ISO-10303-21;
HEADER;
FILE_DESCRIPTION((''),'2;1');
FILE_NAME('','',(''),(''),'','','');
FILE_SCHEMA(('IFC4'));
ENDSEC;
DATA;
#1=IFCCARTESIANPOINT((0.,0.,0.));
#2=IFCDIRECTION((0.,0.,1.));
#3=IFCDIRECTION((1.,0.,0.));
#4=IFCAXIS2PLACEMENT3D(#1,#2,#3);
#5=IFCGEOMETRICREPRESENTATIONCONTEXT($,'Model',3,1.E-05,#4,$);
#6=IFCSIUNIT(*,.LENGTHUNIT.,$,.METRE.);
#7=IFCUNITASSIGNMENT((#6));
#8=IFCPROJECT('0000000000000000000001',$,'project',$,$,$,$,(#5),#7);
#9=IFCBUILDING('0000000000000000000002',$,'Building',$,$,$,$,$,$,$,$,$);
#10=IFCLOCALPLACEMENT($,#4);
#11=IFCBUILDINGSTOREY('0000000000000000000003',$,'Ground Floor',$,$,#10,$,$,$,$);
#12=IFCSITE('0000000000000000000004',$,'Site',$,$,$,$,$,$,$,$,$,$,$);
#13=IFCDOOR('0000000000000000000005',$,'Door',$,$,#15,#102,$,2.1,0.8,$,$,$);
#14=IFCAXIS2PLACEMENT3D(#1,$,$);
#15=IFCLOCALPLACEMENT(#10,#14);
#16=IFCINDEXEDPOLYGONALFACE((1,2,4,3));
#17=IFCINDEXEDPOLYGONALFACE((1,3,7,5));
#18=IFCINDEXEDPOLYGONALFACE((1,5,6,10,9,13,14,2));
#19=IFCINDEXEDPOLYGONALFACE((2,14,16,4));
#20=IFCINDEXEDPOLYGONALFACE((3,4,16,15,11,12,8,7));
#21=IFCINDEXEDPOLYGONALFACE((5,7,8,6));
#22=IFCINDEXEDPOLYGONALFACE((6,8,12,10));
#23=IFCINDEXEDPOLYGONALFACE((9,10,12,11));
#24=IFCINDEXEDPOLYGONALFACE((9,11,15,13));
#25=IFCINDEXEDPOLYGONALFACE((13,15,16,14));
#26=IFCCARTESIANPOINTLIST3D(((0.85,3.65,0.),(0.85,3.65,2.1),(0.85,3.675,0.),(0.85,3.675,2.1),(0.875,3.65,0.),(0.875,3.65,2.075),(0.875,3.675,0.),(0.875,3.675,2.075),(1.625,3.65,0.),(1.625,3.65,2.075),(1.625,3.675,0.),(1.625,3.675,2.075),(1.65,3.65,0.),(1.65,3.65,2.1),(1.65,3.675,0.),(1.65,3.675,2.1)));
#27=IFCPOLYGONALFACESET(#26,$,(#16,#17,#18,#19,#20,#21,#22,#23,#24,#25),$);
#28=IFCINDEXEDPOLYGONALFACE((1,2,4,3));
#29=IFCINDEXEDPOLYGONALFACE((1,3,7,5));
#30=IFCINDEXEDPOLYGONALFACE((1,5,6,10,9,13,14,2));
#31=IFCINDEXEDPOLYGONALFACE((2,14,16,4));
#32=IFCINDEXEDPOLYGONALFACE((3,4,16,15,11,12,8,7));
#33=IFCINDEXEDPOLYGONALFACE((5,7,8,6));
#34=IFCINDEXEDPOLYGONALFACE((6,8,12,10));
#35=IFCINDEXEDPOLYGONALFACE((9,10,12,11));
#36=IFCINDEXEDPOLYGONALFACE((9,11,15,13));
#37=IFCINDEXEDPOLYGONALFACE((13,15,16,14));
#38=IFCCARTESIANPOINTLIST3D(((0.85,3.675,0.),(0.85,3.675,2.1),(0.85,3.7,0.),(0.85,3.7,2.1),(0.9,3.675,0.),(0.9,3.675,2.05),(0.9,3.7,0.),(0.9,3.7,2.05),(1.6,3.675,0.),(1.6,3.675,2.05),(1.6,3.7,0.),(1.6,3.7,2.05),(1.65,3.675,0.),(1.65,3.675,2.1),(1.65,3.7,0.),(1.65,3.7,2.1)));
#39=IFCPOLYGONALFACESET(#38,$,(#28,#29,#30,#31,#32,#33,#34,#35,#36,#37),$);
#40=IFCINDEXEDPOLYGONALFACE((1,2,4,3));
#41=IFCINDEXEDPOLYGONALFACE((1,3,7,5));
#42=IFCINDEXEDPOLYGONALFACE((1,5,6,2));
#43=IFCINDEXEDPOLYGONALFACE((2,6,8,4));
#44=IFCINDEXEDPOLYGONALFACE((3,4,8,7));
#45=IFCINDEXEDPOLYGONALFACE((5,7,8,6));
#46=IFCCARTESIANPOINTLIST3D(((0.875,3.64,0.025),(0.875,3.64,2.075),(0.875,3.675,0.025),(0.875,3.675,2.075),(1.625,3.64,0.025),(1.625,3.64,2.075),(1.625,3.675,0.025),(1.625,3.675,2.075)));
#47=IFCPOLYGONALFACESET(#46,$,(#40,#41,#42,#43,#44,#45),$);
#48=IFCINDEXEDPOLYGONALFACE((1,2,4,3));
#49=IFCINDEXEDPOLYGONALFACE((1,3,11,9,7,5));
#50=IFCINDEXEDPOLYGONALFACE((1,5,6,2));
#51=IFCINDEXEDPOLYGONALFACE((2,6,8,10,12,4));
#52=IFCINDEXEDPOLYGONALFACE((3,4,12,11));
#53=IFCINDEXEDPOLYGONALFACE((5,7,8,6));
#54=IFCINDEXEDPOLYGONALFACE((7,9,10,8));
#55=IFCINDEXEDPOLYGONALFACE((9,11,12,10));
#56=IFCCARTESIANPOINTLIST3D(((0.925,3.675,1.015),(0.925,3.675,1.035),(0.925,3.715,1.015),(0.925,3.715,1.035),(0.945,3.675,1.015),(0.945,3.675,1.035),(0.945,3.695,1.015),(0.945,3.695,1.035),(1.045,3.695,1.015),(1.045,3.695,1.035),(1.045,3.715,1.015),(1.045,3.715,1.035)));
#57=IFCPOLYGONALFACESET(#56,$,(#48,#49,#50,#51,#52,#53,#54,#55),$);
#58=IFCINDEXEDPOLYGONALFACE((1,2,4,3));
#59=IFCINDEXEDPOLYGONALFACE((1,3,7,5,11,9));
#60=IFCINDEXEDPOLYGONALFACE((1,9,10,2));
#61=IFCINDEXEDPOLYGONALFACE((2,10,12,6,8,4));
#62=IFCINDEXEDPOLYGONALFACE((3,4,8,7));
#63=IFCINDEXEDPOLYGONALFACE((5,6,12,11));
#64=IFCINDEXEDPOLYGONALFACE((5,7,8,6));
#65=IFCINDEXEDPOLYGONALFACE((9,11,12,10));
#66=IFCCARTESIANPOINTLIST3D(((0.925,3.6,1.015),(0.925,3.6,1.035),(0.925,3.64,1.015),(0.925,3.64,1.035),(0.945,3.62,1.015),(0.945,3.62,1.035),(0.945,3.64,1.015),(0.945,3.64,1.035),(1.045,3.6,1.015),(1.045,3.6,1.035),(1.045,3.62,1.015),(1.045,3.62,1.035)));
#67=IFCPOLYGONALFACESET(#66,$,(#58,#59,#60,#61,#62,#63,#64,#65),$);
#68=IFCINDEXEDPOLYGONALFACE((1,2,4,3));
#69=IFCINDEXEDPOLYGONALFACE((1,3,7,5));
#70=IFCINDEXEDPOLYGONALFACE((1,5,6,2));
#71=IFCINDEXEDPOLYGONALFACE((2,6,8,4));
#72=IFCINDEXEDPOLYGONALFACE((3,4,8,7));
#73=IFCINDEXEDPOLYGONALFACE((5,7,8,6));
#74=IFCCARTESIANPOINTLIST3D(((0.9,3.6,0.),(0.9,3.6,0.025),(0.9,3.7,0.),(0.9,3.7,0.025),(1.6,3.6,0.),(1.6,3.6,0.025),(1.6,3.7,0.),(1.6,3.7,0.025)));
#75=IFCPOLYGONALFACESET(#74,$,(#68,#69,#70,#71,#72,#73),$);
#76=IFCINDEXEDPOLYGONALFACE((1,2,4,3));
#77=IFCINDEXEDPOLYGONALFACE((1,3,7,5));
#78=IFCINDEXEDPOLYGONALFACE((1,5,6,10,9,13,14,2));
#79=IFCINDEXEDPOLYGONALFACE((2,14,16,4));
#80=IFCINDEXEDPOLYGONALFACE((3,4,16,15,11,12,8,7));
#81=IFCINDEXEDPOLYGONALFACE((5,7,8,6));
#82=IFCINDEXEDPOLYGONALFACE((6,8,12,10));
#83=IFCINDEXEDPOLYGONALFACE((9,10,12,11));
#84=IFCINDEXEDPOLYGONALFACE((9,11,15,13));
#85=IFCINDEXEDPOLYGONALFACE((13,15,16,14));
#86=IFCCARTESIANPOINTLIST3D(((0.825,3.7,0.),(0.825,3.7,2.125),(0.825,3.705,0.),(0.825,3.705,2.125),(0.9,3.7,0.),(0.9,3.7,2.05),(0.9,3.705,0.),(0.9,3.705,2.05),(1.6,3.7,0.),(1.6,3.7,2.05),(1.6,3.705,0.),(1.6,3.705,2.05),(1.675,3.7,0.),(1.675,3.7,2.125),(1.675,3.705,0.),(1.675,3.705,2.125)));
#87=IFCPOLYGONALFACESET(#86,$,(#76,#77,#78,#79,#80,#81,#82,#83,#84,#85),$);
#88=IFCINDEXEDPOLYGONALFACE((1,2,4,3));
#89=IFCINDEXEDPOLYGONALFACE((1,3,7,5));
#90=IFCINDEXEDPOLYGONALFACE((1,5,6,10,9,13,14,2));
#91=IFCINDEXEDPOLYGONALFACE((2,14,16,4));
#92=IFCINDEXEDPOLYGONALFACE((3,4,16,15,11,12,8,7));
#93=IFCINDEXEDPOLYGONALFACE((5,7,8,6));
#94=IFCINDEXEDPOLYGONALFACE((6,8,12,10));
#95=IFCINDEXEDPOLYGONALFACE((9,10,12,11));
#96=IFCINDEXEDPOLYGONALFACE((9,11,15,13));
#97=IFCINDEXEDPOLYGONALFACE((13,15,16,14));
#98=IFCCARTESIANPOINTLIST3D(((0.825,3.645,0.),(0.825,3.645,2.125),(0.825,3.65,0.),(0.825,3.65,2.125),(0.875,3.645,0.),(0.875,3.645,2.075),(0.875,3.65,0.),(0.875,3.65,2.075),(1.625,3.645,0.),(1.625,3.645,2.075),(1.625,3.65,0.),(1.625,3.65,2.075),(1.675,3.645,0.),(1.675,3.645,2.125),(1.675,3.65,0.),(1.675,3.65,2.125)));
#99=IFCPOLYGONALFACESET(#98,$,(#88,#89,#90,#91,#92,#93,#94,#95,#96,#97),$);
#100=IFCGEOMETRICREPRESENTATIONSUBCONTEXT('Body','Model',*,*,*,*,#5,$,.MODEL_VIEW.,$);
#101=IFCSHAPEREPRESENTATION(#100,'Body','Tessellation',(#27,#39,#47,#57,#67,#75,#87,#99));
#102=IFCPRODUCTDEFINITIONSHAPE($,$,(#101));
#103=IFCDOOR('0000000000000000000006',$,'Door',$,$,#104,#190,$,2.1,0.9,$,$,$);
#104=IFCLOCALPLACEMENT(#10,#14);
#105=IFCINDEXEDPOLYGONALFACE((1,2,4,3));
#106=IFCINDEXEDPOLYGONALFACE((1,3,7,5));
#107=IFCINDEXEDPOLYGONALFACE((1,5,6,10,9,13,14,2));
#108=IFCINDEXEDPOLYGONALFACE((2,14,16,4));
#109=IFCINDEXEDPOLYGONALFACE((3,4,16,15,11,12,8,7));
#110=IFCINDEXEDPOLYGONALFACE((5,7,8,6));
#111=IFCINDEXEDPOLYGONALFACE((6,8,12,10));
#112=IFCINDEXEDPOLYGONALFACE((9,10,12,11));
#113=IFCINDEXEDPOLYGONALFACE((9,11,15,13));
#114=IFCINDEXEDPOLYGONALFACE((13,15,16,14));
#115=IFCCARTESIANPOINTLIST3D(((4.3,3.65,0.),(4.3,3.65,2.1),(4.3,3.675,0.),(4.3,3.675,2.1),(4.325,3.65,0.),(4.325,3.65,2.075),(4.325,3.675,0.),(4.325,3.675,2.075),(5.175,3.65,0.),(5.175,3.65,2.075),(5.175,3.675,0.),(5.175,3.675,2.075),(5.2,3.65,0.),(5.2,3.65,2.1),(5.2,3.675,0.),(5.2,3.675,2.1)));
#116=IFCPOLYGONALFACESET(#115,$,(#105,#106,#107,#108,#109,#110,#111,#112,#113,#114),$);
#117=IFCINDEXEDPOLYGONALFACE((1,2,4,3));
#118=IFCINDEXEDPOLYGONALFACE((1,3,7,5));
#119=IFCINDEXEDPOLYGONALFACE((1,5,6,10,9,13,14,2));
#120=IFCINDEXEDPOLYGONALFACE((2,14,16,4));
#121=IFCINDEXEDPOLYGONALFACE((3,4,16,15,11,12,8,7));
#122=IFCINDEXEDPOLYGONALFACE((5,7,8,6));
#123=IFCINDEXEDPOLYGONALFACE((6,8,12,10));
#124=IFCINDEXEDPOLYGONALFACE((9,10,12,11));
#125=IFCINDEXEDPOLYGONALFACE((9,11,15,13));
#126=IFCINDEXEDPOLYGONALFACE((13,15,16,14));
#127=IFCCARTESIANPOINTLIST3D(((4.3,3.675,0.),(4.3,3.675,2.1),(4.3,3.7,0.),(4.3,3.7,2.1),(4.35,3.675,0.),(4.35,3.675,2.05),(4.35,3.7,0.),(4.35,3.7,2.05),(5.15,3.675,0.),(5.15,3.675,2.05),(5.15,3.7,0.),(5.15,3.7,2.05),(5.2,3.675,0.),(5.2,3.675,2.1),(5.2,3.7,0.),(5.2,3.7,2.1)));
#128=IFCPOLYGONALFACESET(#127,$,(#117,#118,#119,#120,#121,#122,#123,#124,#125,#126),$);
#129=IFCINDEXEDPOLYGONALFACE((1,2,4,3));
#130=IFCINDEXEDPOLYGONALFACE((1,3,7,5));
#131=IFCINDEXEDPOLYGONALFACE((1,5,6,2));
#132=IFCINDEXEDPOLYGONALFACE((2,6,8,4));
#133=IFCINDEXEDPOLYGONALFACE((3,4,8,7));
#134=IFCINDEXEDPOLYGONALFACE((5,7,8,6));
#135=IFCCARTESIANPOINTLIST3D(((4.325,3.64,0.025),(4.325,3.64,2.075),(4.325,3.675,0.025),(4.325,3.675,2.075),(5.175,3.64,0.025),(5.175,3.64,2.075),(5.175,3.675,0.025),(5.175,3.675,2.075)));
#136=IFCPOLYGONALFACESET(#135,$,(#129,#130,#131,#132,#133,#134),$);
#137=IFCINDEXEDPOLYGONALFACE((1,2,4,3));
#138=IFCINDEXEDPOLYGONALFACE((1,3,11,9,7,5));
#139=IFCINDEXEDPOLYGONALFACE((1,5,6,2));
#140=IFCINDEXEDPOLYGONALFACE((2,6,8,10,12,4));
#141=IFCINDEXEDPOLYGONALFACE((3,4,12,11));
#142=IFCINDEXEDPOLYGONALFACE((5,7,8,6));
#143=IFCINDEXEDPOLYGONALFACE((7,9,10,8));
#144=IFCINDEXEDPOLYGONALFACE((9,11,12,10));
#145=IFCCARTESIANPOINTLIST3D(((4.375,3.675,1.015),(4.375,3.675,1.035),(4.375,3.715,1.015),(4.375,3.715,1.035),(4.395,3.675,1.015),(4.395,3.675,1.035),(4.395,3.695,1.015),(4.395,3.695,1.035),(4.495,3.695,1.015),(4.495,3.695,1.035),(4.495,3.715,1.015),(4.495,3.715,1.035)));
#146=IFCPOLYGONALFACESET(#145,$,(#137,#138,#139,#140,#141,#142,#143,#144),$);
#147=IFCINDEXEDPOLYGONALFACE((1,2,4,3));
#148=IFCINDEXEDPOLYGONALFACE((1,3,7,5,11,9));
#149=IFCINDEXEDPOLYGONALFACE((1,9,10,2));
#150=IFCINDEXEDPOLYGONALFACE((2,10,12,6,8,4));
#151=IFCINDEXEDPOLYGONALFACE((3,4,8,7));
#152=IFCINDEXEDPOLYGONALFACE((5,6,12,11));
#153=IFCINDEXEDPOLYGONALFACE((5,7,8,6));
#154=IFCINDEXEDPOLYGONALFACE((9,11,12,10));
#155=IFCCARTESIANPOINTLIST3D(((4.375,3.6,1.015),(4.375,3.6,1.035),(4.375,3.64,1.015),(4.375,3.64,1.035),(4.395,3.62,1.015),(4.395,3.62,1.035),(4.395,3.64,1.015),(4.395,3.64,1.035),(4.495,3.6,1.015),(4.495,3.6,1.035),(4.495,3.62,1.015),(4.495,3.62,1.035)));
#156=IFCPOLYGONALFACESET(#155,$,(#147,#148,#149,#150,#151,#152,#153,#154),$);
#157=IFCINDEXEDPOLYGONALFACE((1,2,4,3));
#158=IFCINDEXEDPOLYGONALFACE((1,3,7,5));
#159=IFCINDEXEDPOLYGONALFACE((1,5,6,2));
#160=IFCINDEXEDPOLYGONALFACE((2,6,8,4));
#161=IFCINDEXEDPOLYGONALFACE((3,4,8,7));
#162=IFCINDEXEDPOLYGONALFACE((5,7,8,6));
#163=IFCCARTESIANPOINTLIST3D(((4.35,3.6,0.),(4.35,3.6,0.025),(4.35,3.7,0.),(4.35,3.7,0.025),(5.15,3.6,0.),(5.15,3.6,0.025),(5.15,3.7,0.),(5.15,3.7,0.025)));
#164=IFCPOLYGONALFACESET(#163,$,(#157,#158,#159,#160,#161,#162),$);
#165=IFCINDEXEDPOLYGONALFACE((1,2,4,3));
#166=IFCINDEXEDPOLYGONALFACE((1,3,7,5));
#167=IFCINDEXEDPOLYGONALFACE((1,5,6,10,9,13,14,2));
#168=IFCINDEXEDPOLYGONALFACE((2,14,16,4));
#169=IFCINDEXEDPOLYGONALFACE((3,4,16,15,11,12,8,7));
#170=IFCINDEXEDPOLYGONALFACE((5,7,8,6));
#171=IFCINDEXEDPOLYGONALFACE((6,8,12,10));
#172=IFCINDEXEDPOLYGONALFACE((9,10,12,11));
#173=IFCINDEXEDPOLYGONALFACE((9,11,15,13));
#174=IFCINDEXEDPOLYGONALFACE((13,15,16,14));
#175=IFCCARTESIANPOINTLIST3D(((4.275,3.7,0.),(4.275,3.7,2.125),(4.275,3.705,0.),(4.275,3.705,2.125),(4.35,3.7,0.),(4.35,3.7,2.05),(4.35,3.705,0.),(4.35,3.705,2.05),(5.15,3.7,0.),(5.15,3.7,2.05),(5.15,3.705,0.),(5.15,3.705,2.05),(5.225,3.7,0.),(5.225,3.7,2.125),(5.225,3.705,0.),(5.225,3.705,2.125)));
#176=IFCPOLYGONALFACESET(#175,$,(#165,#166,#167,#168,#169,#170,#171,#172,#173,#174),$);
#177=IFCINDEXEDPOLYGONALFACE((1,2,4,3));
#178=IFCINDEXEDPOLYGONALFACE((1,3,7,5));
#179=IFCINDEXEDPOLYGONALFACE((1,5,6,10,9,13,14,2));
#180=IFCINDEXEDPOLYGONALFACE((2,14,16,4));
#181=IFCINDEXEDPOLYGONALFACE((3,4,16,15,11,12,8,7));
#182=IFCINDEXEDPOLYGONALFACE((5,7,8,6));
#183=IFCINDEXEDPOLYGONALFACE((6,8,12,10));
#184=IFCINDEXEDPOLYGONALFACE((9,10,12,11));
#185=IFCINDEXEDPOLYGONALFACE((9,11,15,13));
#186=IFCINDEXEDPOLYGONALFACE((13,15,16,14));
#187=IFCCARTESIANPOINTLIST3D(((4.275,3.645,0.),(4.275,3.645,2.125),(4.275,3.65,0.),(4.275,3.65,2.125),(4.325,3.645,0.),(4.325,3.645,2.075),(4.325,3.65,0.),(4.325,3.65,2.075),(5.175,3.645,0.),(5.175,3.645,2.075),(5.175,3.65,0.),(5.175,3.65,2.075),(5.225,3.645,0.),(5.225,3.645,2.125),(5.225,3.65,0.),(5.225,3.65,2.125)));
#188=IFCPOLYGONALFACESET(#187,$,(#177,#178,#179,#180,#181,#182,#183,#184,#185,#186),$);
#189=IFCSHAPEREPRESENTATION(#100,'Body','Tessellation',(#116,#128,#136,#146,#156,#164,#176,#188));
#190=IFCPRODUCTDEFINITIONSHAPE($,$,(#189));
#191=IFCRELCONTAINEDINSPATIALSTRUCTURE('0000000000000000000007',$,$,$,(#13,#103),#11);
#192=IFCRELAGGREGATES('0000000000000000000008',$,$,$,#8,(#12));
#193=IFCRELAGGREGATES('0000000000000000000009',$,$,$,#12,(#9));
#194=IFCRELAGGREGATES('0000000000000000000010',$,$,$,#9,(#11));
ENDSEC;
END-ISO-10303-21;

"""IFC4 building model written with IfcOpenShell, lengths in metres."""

from ifc_helpers import new_model, si_unit, frame, origin_with_axes, place, context, subcontext, project, spatial, line, indexed_curve, outline, extrude, element, save


model = new_model("IFC4")

# Units and contexts
model_context = context("Model", 3, precision=1e-05, world=origin_with_axes())
body_context = subcontext(model_context, "Body", "Model", "MODEL_VIEW")
ifc_project = project(units=[si_unit("LENGTHUNIT", "METRE")], contexts=[model_context])

# Site, building, storey
site = spatial("IfcSite", under=ifc_project, Name="Site")
building = spatial("IfcBuilding", under=site, Name="Building")
storey_placement = place(None, origin_with_axes())
storey = spatial("IfcBuildingStorey", under=building, at=storey_placement, Name="Ground Floor")

# Doors
door_1_placement = place(storey_placement, frame((1.65, 3.7, 0.0), z_axis=(0.0, 0.0, 1.0), x_axis=(-1.0, 0.0, 0.0)))
element("IfcDoor", 1, at=door_1_placement, inside=storey, Name="Door", OverallHeight=2.1, OverallWidth=0.8, context=body_context, shape_type="SweptSolid", body=[
    extrude(outline(indexed_curve([(0.0, 0.0), (0.0, 2.1), (0.8, 2.1), (0.8, 0.0), (0.775, 0.0), (0.775, 2.075), (0.025, 2.075), (0.025, 0.0)], segments=[line(1, 2, 3, 4, 5, 6, 7, 8, 1)])), frame((0.0, 0.025, 0.0), z_axis=(0.0, -1.0, 0.0), x_axis=(1.0, 0.0, 0.0)), (0.0, 0.0, -1.0), 0.025),
    extrude(outline(indexed_curve([(0.0, 0.0), (0.0, 2.1), (0.8, 2.1), (0.8, 0.0), (0.75, 0.0), (0.75, 2.05), (0.05, 2.05), (0.05, 0.0)], segments=[line(1, 2, 3, 4, 5, 6, 7, 8, 1)])), frame((0.0, 0.0, 0.0), z_axis=(0.0, -1.0, 0.0), x_axis=(1.0, 0.0, 0.0)), (0.0, 0.0, -1.0), 0.025),
    extrude(outline(indexed_curve([(0.0, 0.0), (0.75, 0.0), (0.75, 0.035), (0.0, 0.035)], segments=[line(1, 2, 3, 4, 1)])), frame((0.025, 0.025, 0.025), z_axis=(0.0, 0.0, 1.0), x_axis=(1.0, 0.0, 0.0)), (0.0, 0.0, 1.0), 2.05),
    extrude(outline(indexed_curve([(0.0, 0.0), (0.0, -0.04), (-0.12, -0.04), (-0.12, -0.02), (-0.02, -0.02), (-0.02, 0.0)], segments=[line(1, 2, 3, 4, 5, 6, 1)])), frame((0.725, 0.025, 1.015), z_axis=(0.0, 0.0, 1.0), x_axis=(1.0, 0.0, 0.0)), (0.0, 0.0, 1.0), 0.02),
    extrude(outline(indexed_curve([(0.0, 0.0), (0.0, 0.04), (-0.12, 0.04), (-0.12, 0.02), (-0.02, 0.02), (-0.02, 0.0)], segments=[line(1, 2, 3, 4, 5, 6, 1)])), frame((0.725, 0.06, 1.015), z_axis=(0.0, 0.0, 1.0), x_axis=(1.0, 0.0, 0.0)), (0.0, 0.0, 1.0), 0.02),
    extrude(outline(indexed_curve([(0.0, 0.0), (0.7, 0.0), (0.7, 0.1), (0.0, 0.1)], segments=[line(1, 2, 3, 4, 1)])), frame((0.05, 0.0, 0.0), z_axis=(0.0, 0.0, 1.0), x_axis=(1.0, 0.0, 0.0)), (0.0, 0.0, 1.0), 0.025),
    extrude(outline(indexed_curve([(0.0, 0.0), (0.0, 2.125), (0.85, 2.125), (0.85, 0.0), (0.775, 0.0), (0.775, 2.05), (0.075, 2.05), (0.075, 0.0)], segments=[line(1, 2, 3, 4, 5, 6, 7, 8, 1)])), frame((-0.025, -0.005, 0.0), z_axis=(0.0, -1.0, 0.0), x_axis=(1.0, 0.0, 0.0)), (0.0, 0.0, -1.0), 0.005),
    extrude(outline(indexed_curve([(0.0, 0.0), (0.0, 2.125), (0.85, 2.125), (0.85, 0.0), (0.8, 0.0), (0.8, 2.075), (0.05, 2.075), (0.05, 0.0)], segments=[line(1, 2, 3, 4, 5, 6, 7, 8, 1)])), frame((-0.025, 0.05, 0.0), z_axis=(0.0, -1.0, 0.0), x_axis=(1.0, 0.0, 0.0)), (0.0, 0.0, -1.0), 0.005),
])
door_2_placement = place(storey_placement, frame((5.2, 3.7, 0.0), z_axis=(0.0, 0.0, 1.0), x_axis=(-1.0, 0.0, 0.0)))
element("IfcDoor", 2, at=door_2_placement, inside=storey, Name="Door", OverallHeight=2.1, OverallWidth=0.9, context=body_context, shape_type="SweptSolid", body=[
    extrude(outline(indexed_curve([(0.0, 0.0), (0.0, 2.1), (0.9, 2.1), (0.9, 0.0), (0.875, 0.0), (0.875, 2.075), (0.025, 2.075), (0.025, 0.0)], segments=[line(1, 2, 3, 4, 5, 6, 7, 8, 1)])), frame((0.0, 0.025, 0.0), z_axis=(0.0, -1.0, 0.0), x_axis=(1.0, 0.0, 0.0)), (0.0, 0.0, -1.0), 0.025),
    extrude(outline(indexed_curve([(0.0, 0.0), (0.0, 2.1), (0.9, 2.1), (0.9, 0.0), (0.85, 0.0), (0.85, 2.05), (0.05, 2.05), (0.05, 0.0)], segments=[line(1, 2, 3, 4, 5, 6, 7, 8, 1)])), frame((0.0, 0.0, 0.0), z_axis=(0.0, -1.0, 0.0), x_axis=(1.0, 0.0, 0.0)), (0.0, 0.0, -1.0), 0.025),
    extrude(outline(indexed_curve([(0.0, 0.0), (0.85, 0.0), (0.85, 0.035), (0.0, 0.035)], segments=[line(1, 2, 3, 4, 1)])), frame((0.025, 0.025, 0.025), z_axis=(0.0, 0.0, 1.0), x_axis=(1.0, 0.0, 0.0)), (0.0, 0.0, 1.0), 2.05),
    extrude(outline(indexed_curve([(0.0, 0.0), (0.0, -0.04), (-0.12, -0.04), (-0.12, -0.02), (-0.02, -0.02), (-0.02, 0.0)], segments=[line(1, 2, 3, 4, 5, 6, 1)])), frame((0.825, 0.025, 1.015), z_axis=(0.0, 0.0, 1.0), x_axis=(1.0, 0.0, 0.0)), (0.0, 0.0, 1.0), 0.02),
    extrude(outline(indexed_curve([(0.0, 0.0), (0.0, 0.04), (-0.12, 0.04), (-0.12, 0.02), (-0.02, 0.02), (-0.02, 0.0)], segments=[line(1, 2, 3, 4, 5, 6, 1)])), frame((0.825, 0.06, 1.015), z_axis=(0.0, 0.0, 1.0), x_axis=(1.0, 0.0, 0.0)), (0.0, 0.0, 1.0), 0.02),
    extrude(outline(indexed_curve([(0.0, 0.0), (0.8, 0.0), (0.8, 0.1), (0.0, 0.1)], segments=[line(1, 2, 3, 4, 1)])), frame((0.05, 0.0, 0.0), z_axis=(0.0, 0.0, 1.0), x_axis=(1.0, 0.0, 0.0)), (0.0, 0.0, 1.0), 0.025),
    extrude(outline(indexed_curve([(0.0, 0.0), (0.0, 2.125), (0.95, 2.125), (0.95, 0.0), (0.875, 0.0), (0.875, 2.05), (0.075, 2.05), (0.075, 0.0)], segments=[line(1, 2, 3, 4, 5, 6, 7, 8, 1)])), frame((-0.025, -0.005, 0.0), z_axis=(0.0, -1.0, 0.0), x_axis=(1.0, 0.0, 0.0)), (0.0, 0.0, -1.0), 0.005),
    extrude(outline(indexed_curve([(0.0, 0.0), (0.0, 2.125), (0.95, 2.125), (0.95, 0.0), (0.9, 0.0), (0.9, 2.075), (0.05, 2.075), (0.05, 0.0)], segments=[line(1, 2, 3, 4, 5, 6, 7, 8, 1)])), frame((-0.025, 0.05, 0.0), z_axis=(0.0, -1.0, 0.0), x_axis=(1.0, 0.0, 0.0)), (0.0, 0.0, -1.0), 0.005),
])

save(model, "model.ifc")
